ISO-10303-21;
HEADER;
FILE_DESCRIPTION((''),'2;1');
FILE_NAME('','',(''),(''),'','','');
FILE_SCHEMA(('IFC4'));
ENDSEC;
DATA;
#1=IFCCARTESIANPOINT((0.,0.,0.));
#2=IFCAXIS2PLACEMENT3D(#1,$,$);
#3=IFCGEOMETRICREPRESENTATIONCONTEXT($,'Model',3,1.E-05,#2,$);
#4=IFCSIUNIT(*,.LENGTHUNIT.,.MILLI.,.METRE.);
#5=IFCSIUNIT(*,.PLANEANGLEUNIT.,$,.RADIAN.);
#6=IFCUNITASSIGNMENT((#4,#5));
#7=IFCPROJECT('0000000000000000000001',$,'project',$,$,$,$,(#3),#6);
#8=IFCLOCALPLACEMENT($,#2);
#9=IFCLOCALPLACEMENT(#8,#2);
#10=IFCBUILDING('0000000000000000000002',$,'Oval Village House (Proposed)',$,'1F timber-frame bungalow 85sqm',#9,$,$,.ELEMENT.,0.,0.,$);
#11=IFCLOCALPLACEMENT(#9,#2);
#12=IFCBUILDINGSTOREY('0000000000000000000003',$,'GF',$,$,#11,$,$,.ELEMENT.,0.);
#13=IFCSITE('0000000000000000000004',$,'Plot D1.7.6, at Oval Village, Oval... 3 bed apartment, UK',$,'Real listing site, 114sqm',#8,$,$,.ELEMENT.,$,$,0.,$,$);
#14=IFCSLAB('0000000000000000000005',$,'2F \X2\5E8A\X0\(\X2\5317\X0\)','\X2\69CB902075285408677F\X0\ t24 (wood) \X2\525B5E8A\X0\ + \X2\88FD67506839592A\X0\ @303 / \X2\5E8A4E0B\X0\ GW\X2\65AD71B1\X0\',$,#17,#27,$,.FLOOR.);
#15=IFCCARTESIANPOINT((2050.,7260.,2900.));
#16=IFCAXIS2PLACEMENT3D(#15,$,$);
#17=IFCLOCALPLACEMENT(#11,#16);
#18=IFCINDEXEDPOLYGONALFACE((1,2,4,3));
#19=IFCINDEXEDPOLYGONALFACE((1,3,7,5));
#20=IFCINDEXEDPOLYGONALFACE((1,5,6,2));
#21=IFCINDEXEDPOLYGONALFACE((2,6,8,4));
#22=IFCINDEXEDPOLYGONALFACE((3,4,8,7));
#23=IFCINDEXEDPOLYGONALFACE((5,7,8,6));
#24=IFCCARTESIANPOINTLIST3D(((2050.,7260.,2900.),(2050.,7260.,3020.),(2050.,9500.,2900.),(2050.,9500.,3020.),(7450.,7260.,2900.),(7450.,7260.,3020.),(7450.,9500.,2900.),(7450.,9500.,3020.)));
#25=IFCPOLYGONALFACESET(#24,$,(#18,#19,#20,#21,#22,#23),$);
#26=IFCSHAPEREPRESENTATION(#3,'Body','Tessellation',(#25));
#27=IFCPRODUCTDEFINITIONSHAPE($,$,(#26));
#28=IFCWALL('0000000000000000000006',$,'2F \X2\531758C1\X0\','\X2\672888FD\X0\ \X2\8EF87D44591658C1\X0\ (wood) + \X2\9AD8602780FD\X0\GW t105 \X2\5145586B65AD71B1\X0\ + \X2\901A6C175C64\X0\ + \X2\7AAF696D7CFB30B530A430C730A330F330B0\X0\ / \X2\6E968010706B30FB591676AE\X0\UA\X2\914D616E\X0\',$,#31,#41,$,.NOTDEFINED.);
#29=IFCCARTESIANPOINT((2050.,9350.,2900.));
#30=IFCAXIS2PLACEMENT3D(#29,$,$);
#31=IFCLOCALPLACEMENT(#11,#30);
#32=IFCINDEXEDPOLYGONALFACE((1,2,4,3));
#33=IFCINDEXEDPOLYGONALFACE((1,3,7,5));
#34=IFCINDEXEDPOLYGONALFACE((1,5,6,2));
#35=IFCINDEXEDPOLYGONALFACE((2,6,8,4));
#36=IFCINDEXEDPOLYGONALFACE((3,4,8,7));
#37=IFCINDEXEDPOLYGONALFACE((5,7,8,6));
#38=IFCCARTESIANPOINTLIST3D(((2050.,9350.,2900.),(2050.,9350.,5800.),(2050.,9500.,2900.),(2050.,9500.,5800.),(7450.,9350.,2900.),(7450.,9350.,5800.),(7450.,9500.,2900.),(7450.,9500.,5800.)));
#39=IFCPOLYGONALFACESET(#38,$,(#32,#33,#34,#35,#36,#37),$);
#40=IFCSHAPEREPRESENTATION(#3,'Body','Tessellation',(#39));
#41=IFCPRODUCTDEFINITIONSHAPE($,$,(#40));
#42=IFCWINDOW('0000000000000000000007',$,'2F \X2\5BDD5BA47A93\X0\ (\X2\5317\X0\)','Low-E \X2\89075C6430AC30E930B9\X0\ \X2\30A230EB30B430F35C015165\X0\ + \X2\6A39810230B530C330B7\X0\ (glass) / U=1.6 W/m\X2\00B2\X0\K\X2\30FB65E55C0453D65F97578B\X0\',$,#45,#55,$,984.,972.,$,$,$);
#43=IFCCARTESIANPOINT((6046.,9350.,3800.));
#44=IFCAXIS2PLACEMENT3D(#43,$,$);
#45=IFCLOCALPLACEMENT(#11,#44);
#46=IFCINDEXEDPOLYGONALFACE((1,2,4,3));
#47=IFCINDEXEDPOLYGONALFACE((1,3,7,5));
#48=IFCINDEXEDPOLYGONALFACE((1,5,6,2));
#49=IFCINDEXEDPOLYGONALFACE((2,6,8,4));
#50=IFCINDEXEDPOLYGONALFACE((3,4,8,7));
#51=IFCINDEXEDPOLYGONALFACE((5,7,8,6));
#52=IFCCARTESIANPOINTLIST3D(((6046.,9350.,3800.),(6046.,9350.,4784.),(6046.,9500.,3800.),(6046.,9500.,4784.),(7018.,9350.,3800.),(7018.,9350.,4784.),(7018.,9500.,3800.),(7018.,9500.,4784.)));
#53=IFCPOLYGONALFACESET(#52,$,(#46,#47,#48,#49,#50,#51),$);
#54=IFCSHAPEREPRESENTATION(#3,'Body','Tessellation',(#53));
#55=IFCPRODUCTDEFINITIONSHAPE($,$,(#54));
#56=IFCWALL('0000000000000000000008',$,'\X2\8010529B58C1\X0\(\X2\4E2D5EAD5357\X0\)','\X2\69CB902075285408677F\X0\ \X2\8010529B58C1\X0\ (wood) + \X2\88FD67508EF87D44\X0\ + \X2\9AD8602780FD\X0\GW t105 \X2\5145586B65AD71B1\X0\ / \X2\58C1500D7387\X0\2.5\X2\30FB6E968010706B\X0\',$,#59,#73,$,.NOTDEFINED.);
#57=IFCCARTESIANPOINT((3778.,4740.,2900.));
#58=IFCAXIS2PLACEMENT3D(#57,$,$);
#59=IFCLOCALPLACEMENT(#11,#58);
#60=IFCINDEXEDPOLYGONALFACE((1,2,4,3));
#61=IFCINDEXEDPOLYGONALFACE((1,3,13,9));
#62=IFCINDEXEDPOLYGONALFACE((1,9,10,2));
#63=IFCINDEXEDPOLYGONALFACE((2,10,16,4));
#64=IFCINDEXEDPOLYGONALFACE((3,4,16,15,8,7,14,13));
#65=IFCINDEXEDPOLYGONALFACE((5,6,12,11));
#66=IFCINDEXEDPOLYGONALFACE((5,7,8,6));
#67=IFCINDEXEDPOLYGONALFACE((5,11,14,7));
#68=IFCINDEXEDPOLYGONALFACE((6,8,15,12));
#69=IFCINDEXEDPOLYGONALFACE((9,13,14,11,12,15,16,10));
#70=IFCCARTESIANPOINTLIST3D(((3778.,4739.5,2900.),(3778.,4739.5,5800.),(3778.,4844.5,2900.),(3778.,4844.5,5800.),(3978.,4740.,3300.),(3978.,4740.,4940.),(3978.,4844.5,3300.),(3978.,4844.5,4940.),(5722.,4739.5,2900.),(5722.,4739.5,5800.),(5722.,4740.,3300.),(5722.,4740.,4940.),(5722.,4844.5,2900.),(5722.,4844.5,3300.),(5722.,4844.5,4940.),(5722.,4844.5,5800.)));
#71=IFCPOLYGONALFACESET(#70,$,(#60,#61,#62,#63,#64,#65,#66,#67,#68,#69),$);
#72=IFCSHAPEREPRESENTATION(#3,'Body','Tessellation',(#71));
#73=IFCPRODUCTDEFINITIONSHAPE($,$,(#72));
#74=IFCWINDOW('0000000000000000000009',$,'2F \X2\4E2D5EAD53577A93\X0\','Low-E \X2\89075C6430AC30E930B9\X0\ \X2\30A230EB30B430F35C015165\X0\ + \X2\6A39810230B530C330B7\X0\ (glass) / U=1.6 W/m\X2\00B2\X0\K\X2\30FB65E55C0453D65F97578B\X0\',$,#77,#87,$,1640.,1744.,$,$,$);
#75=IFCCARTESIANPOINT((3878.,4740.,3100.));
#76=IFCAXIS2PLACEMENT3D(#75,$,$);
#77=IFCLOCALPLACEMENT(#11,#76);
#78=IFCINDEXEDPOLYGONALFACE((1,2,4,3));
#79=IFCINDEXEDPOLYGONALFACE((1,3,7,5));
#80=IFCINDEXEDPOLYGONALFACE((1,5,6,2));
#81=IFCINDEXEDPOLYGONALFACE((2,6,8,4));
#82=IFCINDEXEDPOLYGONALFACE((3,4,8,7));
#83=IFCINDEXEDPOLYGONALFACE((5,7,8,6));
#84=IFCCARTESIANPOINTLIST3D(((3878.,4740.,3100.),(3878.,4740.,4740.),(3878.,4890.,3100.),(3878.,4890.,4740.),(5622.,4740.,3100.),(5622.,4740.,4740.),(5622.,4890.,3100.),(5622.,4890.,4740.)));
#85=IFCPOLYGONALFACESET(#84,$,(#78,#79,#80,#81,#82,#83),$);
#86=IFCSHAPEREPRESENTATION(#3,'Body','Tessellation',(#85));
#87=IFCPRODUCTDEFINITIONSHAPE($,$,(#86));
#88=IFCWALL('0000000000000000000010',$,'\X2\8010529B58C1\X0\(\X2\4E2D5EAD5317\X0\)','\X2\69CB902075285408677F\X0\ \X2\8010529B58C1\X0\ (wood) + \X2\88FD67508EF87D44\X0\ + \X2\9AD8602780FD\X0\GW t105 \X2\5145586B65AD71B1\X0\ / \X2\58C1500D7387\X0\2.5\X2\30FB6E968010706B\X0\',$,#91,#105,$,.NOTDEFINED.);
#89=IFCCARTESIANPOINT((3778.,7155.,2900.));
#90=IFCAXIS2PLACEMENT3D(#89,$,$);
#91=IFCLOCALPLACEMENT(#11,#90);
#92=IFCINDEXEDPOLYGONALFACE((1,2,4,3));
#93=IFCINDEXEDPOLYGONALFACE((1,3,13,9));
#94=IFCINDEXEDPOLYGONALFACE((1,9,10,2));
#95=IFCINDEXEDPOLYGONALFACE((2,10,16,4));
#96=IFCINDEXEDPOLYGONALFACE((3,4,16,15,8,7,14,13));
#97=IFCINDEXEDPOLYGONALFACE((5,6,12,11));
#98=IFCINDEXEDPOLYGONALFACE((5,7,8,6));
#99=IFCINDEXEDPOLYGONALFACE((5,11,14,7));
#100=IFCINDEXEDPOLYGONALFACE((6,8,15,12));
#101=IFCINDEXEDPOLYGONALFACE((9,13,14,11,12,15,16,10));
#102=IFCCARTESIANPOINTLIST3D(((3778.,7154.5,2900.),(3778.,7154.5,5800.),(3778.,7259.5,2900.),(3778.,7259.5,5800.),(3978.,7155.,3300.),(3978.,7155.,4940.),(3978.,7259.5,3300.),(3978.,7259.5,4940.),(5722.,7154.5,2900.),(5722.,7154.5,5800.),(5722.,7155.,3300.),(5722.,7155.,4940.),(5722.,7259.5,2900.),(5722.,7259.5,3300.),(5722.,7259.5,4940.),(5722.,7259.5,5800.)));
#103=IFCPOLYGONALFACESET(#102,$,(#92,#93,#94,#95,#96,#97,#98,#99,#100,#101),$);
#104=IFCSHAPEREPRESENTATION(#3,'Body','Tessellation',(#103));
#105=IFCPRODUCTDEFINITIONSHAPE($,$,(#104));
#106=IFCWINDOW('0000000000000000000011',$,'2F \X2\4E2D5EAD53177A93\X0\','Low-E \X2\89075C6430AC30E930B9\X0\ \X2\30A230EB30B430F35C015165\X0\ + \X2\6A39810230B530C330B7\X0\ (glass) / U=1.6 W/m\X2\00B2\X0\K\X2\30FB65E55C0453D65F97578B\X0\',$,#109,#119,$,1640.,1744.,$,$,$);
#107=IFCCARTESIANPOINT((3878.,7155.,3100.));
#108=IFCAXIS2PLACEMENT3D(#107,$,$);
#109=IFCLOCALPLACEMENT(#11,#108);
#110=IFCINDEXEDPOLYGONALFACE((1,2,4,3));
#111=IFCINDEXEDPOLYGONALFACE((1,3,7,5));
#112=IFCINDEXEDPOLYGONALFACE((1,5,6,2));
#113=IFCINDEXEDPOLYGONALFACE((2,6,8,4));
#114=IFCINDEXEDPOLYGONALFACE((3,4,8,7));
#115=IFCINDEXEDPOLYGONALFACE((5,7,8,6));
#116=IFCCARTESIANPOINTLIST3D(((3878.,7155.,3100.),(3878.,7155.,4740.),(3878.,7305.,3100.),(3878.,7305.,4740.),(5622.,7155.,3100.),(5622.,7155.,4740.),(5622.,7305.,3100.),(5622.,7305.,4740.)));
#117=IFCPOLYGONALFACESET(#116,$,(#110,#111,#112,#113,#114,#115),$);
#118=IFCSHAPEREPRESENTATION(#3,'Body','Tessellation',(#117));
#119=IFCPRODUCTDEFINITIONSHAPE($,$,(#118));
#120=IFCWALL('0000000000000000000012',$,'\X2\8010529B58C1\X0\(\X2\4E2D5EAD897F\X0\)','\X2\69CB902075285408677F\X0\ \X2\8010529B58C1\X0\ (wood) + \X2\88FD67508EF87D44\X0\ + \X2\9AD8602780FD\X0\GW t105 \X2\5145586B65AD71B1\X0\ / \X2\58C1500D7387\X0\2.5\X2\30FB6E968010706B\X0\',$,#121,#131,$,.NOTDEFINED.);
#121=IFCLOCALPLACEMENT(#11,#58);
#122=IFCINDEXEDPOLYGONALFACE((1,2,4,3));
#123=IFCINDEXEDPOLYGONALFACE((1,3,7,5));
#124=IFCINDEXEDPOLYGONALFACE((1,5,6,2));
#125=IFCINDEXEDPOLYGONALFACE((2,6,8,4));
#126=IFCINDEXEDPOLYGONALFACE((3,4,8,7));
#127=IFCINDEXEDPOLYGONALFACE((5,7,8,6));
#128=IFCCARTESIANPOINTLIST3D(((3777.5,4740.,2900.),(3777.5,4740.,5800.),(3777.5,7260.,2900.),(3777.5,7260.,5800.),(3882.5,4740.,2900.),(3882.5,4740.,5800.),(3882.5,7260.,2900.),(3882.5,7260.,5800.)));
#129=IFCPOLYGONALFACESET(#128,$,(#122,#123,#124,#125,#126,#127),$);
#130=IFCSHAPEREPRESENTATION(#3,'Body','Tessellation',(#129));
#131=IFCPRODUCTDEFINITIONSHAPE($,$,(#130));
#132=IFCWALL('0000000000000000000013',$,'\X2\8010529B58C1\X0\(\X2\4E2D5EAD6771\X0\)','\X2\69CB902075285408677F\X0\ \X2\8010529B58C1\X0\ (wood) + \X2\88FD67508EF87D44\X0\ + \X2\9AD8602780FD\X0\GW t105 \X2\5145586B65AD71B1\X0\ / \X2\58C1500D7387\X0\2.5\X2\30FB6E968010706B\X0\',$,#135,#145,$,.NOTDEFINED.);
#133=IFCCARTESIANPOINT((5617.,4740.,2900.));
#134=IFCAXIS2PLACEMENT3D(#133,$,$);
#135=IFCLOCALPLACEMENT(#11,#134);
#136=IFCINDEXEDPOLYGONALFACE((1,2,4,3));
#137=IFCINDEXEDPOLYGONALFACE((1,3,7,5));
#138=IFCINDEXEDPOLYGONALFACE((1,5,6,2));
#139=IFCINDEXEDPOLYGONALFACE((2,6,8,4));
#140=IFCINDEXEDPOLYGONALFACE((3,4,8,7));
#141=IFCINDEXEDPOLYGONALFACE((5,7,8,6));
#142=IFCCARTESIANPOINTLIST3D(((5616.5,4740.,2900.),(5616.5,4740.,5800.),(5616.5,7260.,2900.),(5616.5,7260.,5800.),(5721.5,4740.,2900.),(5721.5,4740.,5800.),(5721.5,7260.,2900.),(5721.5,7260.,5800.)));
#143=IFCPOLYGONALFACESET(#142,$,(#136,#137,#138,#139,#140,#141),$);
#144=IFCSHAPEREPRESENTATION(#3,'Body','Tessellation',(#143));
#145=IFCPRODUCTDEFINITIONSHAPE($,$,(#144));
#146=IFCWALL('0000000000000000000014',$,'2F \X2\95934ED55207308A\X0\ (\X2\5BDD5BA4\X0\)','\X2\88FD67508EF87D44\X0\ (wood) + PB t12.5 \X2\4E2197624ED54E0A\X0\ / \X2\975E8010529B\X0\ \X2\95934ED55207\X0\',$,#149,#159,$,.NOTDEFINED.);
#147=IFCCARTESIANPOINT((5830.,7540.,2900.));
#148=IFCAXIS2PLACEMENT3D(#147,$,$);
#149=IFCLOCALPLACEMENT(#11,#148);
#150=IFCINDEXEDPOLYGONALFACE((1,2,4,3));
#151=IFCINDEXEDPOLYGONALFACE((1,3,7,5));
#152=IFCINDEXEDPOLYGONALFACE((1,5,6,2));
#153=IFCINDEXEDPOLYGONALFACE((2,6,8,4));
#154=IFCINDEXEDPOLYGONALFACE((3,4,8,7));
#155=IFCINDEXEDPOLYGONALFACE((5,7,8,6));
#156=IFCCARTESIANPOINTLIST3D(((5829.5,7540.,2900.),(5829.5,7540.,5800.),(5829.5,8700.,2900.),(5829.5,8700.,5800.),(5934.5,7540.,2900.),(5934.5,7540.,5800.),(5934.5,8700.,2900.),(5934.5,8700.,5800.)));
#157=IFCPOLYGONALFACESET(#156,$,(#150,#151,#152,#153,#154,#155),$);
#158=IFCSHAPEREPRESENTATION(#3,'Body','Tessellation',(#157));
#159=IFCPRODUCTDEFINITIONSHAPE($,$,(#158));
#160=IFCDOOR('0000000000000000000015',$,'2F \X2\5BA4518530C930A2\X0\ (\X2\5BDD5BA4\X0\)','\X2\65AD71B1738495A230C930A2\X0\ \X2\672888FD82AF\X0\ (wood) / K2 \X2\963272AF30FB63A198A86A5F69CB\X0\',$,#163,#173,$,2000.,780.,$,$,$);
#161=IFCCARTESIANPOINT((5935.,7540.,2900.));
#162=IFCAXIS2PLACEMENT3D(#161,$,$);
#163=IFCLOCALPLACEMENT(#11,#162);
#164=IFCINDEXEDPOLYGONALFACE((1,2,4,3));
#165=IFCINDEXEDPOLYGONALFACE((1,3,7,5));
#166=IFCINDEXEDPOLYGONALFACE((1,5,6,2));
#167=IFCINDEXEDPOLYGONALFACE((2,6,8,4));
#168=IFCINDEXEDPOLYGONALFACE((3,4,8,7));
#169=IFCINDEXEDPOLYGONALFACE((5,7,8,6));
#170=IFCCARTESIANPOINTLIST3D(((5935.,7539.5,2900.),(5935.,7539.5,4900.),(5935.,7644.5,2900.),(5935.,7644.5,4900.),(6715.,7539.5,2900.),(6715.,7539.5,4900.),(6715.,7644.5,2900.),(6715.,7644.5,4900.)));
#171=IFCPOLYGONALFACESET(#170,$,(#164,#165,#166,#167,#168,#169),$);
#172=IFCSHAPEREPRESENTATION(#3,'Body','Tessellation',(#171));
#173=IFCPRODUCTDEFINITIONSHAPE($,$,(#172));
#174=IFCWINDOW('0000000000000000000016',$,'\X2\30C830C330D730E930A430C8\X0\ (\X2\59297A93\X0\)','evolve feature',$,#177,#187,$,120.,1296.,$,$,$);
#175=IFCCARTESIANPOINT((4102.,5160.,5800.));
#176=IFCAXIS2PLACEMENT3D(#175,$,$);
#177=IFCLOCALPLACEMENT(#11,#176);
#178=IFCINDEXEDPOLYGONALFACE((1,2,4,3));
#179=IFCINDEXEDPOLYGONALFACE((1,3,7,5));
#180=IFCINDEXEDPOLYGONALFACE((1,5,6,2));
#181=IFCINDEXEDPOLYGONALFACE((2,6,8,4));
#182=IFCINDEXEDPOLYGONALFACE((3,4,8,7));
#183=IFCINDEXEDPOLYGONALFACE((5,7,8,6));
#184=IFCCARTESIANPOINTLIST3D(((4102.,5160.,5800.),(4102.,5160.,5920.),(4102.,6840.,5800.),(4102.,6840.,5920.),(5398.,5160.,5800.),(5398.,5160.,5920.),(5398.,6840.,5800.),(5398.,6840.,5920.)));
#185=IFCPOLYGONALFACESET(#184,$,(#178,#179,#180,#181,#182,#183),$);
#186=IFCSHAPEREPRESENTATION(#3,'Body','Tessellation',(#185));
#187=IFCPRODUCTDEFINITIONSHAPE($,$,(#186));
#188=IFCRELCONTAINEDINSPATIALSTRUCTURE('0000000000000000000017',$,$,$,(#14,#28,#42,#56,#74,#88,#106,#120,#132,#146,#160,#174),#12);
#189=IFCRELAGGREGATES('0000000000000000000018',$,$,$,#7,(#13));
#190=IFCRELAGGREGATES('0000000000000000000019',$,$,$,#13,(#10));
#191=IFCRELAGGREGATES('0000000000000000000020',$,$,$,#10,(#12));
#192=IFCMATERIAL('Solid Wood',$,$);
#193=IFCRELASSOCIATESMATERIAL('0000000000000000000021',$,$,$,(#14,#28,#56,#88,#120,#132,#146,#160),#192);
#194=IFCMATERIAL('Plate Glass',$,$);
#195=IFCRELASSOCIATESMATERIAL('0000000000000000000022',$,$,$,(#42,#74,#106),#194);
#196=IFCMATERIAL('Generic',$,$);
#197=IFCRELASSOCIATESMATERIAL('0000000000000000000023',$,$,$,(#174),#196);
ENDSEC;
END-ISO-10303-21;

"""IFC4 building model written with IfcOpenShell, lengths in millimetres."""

from ifc_helpers import new_model, si_unit, frame, frame_2d, origin, place, context, project, spatial, rectangle, extrude, material, element, fill, save


model = new_model("IFC4")

# Units and contexts
model_context = context("Model", 3, precision=1e-05, world=origin())
ifc_project = project(units=[si_unit("LENGTHUNIT", "METRE", prefix="MILLI"), si_unit("PLANEANGLEUNIT", "RADIAN")], contexts=[model_context])

# Site, building, storey
site_placement = place(None, origin())
site = spatial("IfcSite", under=ifc_project, at=site_placement, Name="Plot D1.7.6, at Oval Village, Oval... 3 bed apartment, UK", ObjectType="Real listing site, 114sqm", CompositionType="ELEMENT", RefElevation=0.0)
building_placement = place(site_placement, origin())
building = spatial("IfcBuilding", under=site, at=building_placement, Name="Oval Village House (Proposed)", ObjectType="1F timber-frame bungalow 85sqm", CompositionType="ELEMENT", ElevationOfRefHeight=0.0, ElevationOfTerrain=0.0)
storey_placement = place(building_placement, origin())
storey = spatial("IfcBuildingStorey", under=building, at=storey_placement, Name="GF", CompositionType="ELEMENT", Elevation=0.0)

# Slab
ifc_material_1 = material(Name="Solid Wood")
slab_placement = place(storey_placement, frame((2050.0, 7260.0, 2900.0)))
element("IfcSlab", 1, at=slab_placement, inside=storey, material=ifc_material_1, Name="2F 床(北)", Description="構造用合板 t24 (wood) 剛床 + 製材根太 @303 / 床下 GW断熱", PredefinedType="FLOOR", context=model_context, shape_type="SweptSolid", body=[
    extrude(rectangle(XDim=5400.0, YDim=2240.0, at=frame_2d((2700.0, 1120.0))), frame((2050.0, 7260.0, 2900.0)), (0.0, 0.0, 1.0), 120.0),
])

# Walls, openings, windows
wall_1_placement = place(storey_placement, frame((2050.0, 9350.0, 2900.0)))
wall_1 = element("IfcWall", 2, at=wall_1_placement, inside=storey, material=ifc_material_1, Name="2F 北壁", Description="木製 軸組外壁 (wood) + 高性能GW t105 充填断熱 + 通気層 + 窯業系サイディング / 準耐火・外皮UA配慮", PredefinedType="NOTDEFINED", context=model_context, shape_type="SweptSolid", body=[
    extrude(rectangle(XDim=5400.0, YDim=150.0, at=frame_2d((2700.0, 75.0))), frame((2050.0, 9350.0, 2900.0)), (0.0, 0.0, 1.0), 2900.0),
])
opening_1_placement = place(storey_placement, frame((6046.0, 9350.0, 3800.0)))
opening_1 = element("IfcOpeningElement", 3, at=opening_1_placement, cuts=wall_1, PredefinedType="NOTDEFINED", context=model_context, shape_type="SweptSolid", body=[
    extrude(rectangle(XDim=972.0, YDim=150.0, at=frame_2d((486.0, 75.0))), frame((6046.0, 9350.0, 3800.0)), (0.0, 0.0, 1.0), 984.0),
])
ifc_material_2 = material(Name="Plate Glass")
window_1_placement = place(storey_placement, frame((6046.0, 9350.0, 3800.0)))
window_1 = element("IfcWindow", 4, at=window_1_placement, inside=storey, material=ifc_material_2, Name="2F 寝室窓 (北)", Description="Low-E 複層ガラス アルゴン封入 + 樹脂サッシ (glass) / U=1.6 W/m²K・日射取得型", OverallHeight=984.0, OverallWidth=972.0, context=model_context, shape_type="SweptSolid", body=[
    extrude(rectangle(XDim=972.0, YDim=150.0, at=frame_2d((486.0, 75.0))), frame((6046.0, 9350.0, 3800.0)), (0.0, 0.0, 1.0), 984.0),
])
fill(opening_1, window_1)
wall_2_placement = place(storey_placement, frame((3778.0, 4740.0, 2900.0)))
wall_2 = element("IfcWall", 5, at=wall_2_placement, inside=storey, material=ifc_material_1, Name="耐力壁(中庭南)", Description="構造用合板 耐力壁 (wood) + 製材軸組 + 高性能GW t105 充填断熱 / 壁倍率2.5・準耐火", PredefinedType="NOTDEFINED", context=model_context, shape_type="SweptSolid", body=[
    extrude(rectangle(XDim=1944.0, YDim=105.0, at=frame_2d((972.0, 52.0))), frame((3778.0, 4740.0, 2900.0)), (0.0, 0.0, 1.0), 2900.0),
])
opening_2_placement = place(storey_placement, frame((3878.0, 4740.0, 3100.0)))
opening_2 = element("IfcOpeningElement", 6, at=opening_2_placement, cuts=wall_2, PredefinedType="NOTDEFINED", context=model_context, shape_type="SweptSolid", body=[
    extrude(rectangle(XDim=1744.0, YDim=150.0, at=frame_2d((872.0, 75.0))), frame((3878.0, 4740.0, 3100.0)), (0.0, 0.0, 1.0), 1640.0),
])
window_2_placement = place(storey_placement, frame((3878.0, 4740.0, 3100.0)))
window_2 = element("IfcWindow", 7, at=window_2_placement, inside=storey, material=ifc_material_2, Name="2F 中庭南窓", Description="Low-E 複層ガラス アルゴン封入 + 樹脂サッシ (glass) / U=1.6 W/m²K・日射取得型", OverallHeight=1640.0, OverallWidth=1744.0, context=model_context, shape_type="SweptSolid", body=[
    extrude(rectangle(XDim=1744.0, YDim=150.0, at=frame_2d((872.0, 75.0))), frame((3878.0, 4740.0, 3100.0)), (0.0, 0.0, 1.0), 1640.0),
])
fill(opening_2, window_2)
wall_3_placement = place(storey_placement, frame((3778.0, 7155.0, 2900.0)))
wall_3 = element("IfcWall", 8, at=wall_3_placement, inside=storey, material=ifc_material_1, Name="耐力壁(中庭北)", Description="構造用合板 耐力壁 (wood) + 製材軸組 + 高性能GW t105 充填断熱 / 壁倍率2.5・準耐火", PredefinedType="NOTDEFINED", context=model_context, shape_type="SweptSolid", body=[
    extrude(rectangle(XDim=1944.0, YDim=105.0, at=frame_2d((972.0, 52.0))), frame((3778.0, 7155.0, 2900.0)), (0.0, 0.0, 1.0), 2900.0),
])
opening_3_placement = place(storey_placement, frame((3878.0, 7155.0, 3100.0)))
opening_3 = element("IfcOpeningElement", 9, at=opening_3_placement, cuts=wall_3, PredefinedType="NOTDEFINED", context=model_context, shape_type="SweptSolid", body=[
    extrude(rectangle(XDim=1744.0, YDim=150.0, at=frame_2d((872.0, 75.0))), frame((3878.0, 7155.0, 3100.0)), (0.0, 0.0, 1.0), 1640.0),
])
window_3_placement = place(storey_placement, frame((3878.0, 7155.0, 3100.0)))
window_3 = element("IfcWindow", 10, at=window_3_placement, inside=storey, material=ifc_material_2, Name="2F 中庭北窓", Description="Low-E 複層ガラス アルゴン封入 + 樹脂サッシ (glass) / U=1.6 W/m²K・日射取得型", OverallHeight=1640.0, OverallWidth=1744.0, context=model_context, shape_type="SweptSolid", body=[
    extrude(rectangle(XDim=1744.0, YDim=150.0, at=frame_2d((872.0, 75.0))), frame((3878.0, 7155.0, 3100.0)), (0.0, 0.0, 1.0), 1640.0),
])
fill(opening_3, window_3)

# Walls
wall_4_placement = place(storey_placement, frame((3778.0, 4740.0, 2900.0)))
element("IfcWall", 11, at=wall_4_placement, inside=storey, material=ifc_material_1, Name="耐力壁(中庭西)", Description="構造用合板 耐力壁 (wood) + 製材軸組 + 高性能GW t105 充填断熱 / 壁倍率2.5・準耐火", PredefinedType="NOTDEFINED", context=model_context, shape_type="SweptSolid", body=[
    extrude(rectangle(XDim=105.0, YDim=2520.0, at=frame_2d((52.0, 1260.0))), frame((3778.0, 4740.0, 2900.0)), (0.0, 0.0, 1.0), 2900.0),
])
wall_5_placement = place(storey_placement, frame((5617.0, 4740.0, 2900.0)))
element("IfcWall", 12, at=wall_5_placement, inside=storey, material=ifc_material_1, Name="耐力壁(中庭東)", Description="構造用合板 耐力壁 (wood) + 製材軸組 + 高性能GW t105 充填断熱 / 壁倍率2.5・準耐火", PredefinedType="NOTDEFINED", context=model_context, shape_type="SweptSolid", body=[
    extrude(rectangle(XDim=105.0, YDim=2520.0, at=frame_2d((52.0, 1260.0))), frame((5617.0, 4740.0, 2900.0)), (0.0, 0.0, 1.0), 2900.0),
])
wall_6_placement = place(storey_placement, frame((5830.0, 7540.0, 2900.0)))
element("IfcWall", 13, at=wall_6_placement, inside=storey, material=ifc_material_1, Name="2F 間仕切り (寝室)", Description="製材軸組 (wood) + PB t12.5 両面仕上 / 非耐力 間仕切", PredefinedType="NOTDEFINED", context=model_context, shape_type="SweptSolid", body=[
    extrude(rectangle(XDim=105.0, YDim=1160.0, at=frame_2d((52.0, 580.0))), frame((5830.0, 7540.0, 2900.0)), (0.0, 0.0, 1.0), 2900.0),
])

# Door
door_placement = place(storey_placement, frame((5935.0, 7540.0, 2900.0)))
element("IfcDoor", 14, at=door_placement, inside=storey, material=ifc_material_1, Name="2F 室内ドア (寝室)", Description="断熱玄関ドア 木製芯 (wood) / K2 防犯・採風機構", OverallHeight=2000.0, OverallWidth=780.0, context=model_context, shape_type="SweptSolid", body=[
    extrude(rectangle(XDim=780.0, YDim=105.0, at=frame_2d((390.0, 52.0))), frame((5935.0, 7540.0, 2900.0)), (0.0, 0.0, 1.0), 2000.0),
])

# Window
ifc_material_3 = material(Name="Generic")
window_4_placement = place(storey_placement, frame((4102.0, 5160.0, 5800.0)))
element("IfcWindow", 15, at=window_4_placement, inside=storey, material=ifc_material_3, Name="トップライト (天窓)", Description="evolve feature", OverallHeight=120.0, OverallWidth=1296.0, context=model_context, shape_type="SweptSolid", body=[
    extrude(rectangle(XDim=1296.0, YDim=1680.0, at=frame_2d((648.0, 840.0))), frame((4102.0, 5160.0, 5800.0)), (0.0, 0.0, 1.0), 120.0),
])

save(model, "model.ifc")
